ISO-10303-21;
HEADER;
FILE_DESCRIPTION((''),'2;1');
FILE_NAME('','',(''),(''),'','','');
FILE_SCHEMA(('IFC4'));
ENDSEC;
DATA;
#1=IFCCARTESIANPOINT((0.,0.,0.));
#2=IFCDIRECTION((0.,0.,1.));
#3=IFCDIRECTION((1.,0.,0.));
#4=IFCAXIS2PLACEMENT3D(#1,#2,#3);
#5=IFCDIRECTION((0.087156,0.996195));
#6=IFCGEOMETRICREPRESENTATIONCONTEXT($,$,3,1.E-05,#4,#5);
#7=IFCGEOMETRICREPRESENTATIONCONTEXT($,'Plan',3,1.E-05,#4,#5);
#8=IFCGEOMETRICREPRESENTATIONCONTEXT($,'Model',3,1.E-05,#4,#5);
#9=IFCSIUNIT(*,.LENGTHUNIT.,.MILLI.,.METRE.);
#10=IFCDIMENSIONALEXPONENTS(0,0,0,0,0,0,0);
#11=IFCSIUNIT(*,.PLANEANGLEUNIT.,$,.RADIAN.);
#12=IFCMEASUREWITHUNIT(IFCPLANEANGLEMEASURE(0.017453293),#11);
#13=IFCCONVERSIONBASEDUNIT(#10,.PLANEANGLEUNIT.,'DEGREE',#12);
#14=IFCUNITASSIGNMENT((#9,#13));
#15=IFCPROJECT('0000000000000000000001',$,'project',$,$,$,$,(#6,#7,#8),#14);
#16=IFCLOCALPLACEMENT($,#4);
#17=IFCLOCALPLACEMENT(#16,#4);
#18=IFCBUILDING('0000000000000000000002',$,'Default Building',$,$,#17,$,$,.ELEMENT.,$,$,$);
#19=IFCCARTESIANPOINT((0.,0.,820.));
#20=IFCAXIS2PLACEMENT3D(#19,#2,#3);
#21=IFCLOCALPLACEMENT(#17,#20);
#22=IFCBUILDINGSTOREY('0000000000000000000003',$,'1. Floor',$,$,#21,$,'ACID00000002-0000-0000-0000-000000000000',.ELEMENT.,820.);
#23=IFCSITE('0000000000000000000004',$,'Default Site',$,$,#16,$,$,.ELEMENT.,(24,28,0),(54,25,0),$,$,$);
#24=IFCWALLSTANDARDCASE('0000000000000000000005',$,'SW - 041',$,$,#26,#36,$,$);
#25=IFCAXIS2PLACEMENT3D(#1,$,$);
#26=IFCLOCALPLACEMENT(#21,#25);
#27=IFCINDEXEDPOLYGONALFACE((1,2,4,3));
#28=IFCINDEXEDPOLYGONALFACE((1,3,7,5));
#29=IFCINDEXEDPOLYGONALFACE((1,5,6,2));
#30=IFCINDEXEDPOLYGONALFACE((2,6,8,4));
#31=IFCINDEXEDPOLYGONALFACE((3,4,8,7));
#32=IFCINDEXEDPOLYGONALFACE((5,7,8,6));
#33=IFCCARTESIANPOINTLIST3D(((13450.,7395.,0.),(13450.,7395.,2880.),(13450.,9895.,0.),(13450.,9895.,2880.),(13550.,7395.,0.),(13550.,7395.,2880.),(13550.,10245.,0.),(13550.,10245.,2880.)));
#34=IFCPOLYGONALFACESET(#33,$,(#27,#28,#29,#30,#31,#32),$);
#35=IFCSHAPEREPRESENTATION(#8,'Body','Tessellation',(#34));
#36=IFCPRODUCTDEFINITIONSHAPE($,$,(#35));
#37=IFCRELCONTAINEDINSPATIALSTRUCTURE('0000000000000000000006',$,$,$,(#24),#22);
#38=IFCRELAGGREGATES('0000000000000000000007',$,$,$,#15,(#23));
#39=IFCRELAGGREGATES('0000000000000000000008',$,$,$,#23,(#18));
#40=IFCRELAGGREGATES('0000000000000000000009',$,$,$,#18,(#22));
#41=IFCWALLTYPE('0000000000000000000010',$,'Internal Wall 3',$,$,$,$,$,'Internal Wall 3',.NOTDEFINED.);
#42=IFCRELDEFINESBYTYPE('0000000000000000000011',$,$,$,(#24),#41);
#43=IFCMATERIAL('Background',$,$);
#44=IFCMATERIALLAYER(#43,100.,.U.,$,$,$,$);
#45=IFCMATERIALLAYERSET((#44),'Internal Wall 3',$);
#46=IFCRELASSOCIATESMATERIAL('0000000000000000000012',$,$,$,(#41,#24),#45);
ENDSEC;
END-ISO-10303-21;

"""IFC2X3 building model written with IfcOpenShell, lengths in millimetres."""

from ifc_helpers import new_model, entity, si_unit, converted_unit, direction, frame, origin_with_axes, place, context, project, spatial, polyline, outline, extrude, material, layer, layer_set, layer_usage, type_object, element, save


model = new_model("IFC2X3")

# Units and contexts
context_of_model = context(None, 3, precision=1e-05, world=origin_with_axes(), true_north=direction((0.087156, 0.996195)))
plan_context = context("Plan", 3, precision=1e-05, world=origin_with_axes(), true_north=direction((0.087156, 0.996195)))
model_context = context("Model", 3, precision=1e-05, world=origin_with_axes(), true_north=direction((0.087156, 0.996195)))
ifc_project = project(units=[si_unit("LENGTHUNIT", "METRE", prefix="MILLI"), converted_unit("PLANEANGLEUNIT", "DEGREE", entity("IfcPlaneAngleMeasure", 0.017453293), si_unit("PLANEANGLEUNIT", "RADIAN"), dimensions=[0, 0, 0, 0, 0, 0, 0])], contexts=[context_of_model, plan_context, model_context])

# Site, building, storey
site_placement = place(None, origin_with_axes())
site = spatial("IfcSite", under=ifc_project, at=site_placement, Name="Default Site", CompositionType="ELEMENT", RefLatitude=(24, 28, 0), RefLongitude=(54, 25, 0))
building_placement = place(site_placement, origin_with_axes())
building = spatial("IfcBuilding", under=site, at=building_placement, Name="Default Building", CompositionType="ELEMENT")
storey_placement = place(building_placement, frame((0.0, 0.0, 820.0), z_axis=(0.0, 0.0, 1.0), x_axis=(1.0, 0.0, 0.0)))
storey = spatial("IfcBuildingStorey", under=building, at=storey_placement, Name="1. Floor", LongName="ACID00000002-0000-0000-0000-000000000000", CompositionType="ELEMENT", Elevation=820.0)

# Shared definitions
ifc_material_1 = material(Name="Background")

# Wall
ifc_layer_1 = layer(ifc_material_1, 100.0, ventilated="UNKNOWN")
ifc_layer_set_1 = layer_set([ifc_layer_1], Name="Internal Wall 3")
ifc_layer_usage_1 = layer_usage(ifc_layer_set_1, "AXIS2", "NEGATIVE", 0.0)
wall_type_1 = type_object("IfcWallType", Name="Internal Wall 3", ElementType="Internal Wall 3", PredefinedType="NOTDEFINED", material=ifc_layer_set_1)
wall_1_placement = place(storey_placement, frame((13550.0, 10245.0, 0.0), z_axis=(0.0, 0.0, 1.0), x_axis=(0.0, -1.0, 0.0)))
element("IfcWallStandardCase", 1, at=wall_1_placement, inside=storey, type_object=wall_type_1, material=ifc_layer_usage_1, Name="SW - 041", context=model_context, shape_type="SweptSolid", body=[
    extrude(outline(polyline([(350.0, -100.0), (2850.0, -100.0), (2850.0, 0.0), (0.0, 0.0), (350.0, -100.0)])), origin_with_axes(), (0.0, 0.0, 1.0), 2880.0),
])

save(model, "model.ifc")
